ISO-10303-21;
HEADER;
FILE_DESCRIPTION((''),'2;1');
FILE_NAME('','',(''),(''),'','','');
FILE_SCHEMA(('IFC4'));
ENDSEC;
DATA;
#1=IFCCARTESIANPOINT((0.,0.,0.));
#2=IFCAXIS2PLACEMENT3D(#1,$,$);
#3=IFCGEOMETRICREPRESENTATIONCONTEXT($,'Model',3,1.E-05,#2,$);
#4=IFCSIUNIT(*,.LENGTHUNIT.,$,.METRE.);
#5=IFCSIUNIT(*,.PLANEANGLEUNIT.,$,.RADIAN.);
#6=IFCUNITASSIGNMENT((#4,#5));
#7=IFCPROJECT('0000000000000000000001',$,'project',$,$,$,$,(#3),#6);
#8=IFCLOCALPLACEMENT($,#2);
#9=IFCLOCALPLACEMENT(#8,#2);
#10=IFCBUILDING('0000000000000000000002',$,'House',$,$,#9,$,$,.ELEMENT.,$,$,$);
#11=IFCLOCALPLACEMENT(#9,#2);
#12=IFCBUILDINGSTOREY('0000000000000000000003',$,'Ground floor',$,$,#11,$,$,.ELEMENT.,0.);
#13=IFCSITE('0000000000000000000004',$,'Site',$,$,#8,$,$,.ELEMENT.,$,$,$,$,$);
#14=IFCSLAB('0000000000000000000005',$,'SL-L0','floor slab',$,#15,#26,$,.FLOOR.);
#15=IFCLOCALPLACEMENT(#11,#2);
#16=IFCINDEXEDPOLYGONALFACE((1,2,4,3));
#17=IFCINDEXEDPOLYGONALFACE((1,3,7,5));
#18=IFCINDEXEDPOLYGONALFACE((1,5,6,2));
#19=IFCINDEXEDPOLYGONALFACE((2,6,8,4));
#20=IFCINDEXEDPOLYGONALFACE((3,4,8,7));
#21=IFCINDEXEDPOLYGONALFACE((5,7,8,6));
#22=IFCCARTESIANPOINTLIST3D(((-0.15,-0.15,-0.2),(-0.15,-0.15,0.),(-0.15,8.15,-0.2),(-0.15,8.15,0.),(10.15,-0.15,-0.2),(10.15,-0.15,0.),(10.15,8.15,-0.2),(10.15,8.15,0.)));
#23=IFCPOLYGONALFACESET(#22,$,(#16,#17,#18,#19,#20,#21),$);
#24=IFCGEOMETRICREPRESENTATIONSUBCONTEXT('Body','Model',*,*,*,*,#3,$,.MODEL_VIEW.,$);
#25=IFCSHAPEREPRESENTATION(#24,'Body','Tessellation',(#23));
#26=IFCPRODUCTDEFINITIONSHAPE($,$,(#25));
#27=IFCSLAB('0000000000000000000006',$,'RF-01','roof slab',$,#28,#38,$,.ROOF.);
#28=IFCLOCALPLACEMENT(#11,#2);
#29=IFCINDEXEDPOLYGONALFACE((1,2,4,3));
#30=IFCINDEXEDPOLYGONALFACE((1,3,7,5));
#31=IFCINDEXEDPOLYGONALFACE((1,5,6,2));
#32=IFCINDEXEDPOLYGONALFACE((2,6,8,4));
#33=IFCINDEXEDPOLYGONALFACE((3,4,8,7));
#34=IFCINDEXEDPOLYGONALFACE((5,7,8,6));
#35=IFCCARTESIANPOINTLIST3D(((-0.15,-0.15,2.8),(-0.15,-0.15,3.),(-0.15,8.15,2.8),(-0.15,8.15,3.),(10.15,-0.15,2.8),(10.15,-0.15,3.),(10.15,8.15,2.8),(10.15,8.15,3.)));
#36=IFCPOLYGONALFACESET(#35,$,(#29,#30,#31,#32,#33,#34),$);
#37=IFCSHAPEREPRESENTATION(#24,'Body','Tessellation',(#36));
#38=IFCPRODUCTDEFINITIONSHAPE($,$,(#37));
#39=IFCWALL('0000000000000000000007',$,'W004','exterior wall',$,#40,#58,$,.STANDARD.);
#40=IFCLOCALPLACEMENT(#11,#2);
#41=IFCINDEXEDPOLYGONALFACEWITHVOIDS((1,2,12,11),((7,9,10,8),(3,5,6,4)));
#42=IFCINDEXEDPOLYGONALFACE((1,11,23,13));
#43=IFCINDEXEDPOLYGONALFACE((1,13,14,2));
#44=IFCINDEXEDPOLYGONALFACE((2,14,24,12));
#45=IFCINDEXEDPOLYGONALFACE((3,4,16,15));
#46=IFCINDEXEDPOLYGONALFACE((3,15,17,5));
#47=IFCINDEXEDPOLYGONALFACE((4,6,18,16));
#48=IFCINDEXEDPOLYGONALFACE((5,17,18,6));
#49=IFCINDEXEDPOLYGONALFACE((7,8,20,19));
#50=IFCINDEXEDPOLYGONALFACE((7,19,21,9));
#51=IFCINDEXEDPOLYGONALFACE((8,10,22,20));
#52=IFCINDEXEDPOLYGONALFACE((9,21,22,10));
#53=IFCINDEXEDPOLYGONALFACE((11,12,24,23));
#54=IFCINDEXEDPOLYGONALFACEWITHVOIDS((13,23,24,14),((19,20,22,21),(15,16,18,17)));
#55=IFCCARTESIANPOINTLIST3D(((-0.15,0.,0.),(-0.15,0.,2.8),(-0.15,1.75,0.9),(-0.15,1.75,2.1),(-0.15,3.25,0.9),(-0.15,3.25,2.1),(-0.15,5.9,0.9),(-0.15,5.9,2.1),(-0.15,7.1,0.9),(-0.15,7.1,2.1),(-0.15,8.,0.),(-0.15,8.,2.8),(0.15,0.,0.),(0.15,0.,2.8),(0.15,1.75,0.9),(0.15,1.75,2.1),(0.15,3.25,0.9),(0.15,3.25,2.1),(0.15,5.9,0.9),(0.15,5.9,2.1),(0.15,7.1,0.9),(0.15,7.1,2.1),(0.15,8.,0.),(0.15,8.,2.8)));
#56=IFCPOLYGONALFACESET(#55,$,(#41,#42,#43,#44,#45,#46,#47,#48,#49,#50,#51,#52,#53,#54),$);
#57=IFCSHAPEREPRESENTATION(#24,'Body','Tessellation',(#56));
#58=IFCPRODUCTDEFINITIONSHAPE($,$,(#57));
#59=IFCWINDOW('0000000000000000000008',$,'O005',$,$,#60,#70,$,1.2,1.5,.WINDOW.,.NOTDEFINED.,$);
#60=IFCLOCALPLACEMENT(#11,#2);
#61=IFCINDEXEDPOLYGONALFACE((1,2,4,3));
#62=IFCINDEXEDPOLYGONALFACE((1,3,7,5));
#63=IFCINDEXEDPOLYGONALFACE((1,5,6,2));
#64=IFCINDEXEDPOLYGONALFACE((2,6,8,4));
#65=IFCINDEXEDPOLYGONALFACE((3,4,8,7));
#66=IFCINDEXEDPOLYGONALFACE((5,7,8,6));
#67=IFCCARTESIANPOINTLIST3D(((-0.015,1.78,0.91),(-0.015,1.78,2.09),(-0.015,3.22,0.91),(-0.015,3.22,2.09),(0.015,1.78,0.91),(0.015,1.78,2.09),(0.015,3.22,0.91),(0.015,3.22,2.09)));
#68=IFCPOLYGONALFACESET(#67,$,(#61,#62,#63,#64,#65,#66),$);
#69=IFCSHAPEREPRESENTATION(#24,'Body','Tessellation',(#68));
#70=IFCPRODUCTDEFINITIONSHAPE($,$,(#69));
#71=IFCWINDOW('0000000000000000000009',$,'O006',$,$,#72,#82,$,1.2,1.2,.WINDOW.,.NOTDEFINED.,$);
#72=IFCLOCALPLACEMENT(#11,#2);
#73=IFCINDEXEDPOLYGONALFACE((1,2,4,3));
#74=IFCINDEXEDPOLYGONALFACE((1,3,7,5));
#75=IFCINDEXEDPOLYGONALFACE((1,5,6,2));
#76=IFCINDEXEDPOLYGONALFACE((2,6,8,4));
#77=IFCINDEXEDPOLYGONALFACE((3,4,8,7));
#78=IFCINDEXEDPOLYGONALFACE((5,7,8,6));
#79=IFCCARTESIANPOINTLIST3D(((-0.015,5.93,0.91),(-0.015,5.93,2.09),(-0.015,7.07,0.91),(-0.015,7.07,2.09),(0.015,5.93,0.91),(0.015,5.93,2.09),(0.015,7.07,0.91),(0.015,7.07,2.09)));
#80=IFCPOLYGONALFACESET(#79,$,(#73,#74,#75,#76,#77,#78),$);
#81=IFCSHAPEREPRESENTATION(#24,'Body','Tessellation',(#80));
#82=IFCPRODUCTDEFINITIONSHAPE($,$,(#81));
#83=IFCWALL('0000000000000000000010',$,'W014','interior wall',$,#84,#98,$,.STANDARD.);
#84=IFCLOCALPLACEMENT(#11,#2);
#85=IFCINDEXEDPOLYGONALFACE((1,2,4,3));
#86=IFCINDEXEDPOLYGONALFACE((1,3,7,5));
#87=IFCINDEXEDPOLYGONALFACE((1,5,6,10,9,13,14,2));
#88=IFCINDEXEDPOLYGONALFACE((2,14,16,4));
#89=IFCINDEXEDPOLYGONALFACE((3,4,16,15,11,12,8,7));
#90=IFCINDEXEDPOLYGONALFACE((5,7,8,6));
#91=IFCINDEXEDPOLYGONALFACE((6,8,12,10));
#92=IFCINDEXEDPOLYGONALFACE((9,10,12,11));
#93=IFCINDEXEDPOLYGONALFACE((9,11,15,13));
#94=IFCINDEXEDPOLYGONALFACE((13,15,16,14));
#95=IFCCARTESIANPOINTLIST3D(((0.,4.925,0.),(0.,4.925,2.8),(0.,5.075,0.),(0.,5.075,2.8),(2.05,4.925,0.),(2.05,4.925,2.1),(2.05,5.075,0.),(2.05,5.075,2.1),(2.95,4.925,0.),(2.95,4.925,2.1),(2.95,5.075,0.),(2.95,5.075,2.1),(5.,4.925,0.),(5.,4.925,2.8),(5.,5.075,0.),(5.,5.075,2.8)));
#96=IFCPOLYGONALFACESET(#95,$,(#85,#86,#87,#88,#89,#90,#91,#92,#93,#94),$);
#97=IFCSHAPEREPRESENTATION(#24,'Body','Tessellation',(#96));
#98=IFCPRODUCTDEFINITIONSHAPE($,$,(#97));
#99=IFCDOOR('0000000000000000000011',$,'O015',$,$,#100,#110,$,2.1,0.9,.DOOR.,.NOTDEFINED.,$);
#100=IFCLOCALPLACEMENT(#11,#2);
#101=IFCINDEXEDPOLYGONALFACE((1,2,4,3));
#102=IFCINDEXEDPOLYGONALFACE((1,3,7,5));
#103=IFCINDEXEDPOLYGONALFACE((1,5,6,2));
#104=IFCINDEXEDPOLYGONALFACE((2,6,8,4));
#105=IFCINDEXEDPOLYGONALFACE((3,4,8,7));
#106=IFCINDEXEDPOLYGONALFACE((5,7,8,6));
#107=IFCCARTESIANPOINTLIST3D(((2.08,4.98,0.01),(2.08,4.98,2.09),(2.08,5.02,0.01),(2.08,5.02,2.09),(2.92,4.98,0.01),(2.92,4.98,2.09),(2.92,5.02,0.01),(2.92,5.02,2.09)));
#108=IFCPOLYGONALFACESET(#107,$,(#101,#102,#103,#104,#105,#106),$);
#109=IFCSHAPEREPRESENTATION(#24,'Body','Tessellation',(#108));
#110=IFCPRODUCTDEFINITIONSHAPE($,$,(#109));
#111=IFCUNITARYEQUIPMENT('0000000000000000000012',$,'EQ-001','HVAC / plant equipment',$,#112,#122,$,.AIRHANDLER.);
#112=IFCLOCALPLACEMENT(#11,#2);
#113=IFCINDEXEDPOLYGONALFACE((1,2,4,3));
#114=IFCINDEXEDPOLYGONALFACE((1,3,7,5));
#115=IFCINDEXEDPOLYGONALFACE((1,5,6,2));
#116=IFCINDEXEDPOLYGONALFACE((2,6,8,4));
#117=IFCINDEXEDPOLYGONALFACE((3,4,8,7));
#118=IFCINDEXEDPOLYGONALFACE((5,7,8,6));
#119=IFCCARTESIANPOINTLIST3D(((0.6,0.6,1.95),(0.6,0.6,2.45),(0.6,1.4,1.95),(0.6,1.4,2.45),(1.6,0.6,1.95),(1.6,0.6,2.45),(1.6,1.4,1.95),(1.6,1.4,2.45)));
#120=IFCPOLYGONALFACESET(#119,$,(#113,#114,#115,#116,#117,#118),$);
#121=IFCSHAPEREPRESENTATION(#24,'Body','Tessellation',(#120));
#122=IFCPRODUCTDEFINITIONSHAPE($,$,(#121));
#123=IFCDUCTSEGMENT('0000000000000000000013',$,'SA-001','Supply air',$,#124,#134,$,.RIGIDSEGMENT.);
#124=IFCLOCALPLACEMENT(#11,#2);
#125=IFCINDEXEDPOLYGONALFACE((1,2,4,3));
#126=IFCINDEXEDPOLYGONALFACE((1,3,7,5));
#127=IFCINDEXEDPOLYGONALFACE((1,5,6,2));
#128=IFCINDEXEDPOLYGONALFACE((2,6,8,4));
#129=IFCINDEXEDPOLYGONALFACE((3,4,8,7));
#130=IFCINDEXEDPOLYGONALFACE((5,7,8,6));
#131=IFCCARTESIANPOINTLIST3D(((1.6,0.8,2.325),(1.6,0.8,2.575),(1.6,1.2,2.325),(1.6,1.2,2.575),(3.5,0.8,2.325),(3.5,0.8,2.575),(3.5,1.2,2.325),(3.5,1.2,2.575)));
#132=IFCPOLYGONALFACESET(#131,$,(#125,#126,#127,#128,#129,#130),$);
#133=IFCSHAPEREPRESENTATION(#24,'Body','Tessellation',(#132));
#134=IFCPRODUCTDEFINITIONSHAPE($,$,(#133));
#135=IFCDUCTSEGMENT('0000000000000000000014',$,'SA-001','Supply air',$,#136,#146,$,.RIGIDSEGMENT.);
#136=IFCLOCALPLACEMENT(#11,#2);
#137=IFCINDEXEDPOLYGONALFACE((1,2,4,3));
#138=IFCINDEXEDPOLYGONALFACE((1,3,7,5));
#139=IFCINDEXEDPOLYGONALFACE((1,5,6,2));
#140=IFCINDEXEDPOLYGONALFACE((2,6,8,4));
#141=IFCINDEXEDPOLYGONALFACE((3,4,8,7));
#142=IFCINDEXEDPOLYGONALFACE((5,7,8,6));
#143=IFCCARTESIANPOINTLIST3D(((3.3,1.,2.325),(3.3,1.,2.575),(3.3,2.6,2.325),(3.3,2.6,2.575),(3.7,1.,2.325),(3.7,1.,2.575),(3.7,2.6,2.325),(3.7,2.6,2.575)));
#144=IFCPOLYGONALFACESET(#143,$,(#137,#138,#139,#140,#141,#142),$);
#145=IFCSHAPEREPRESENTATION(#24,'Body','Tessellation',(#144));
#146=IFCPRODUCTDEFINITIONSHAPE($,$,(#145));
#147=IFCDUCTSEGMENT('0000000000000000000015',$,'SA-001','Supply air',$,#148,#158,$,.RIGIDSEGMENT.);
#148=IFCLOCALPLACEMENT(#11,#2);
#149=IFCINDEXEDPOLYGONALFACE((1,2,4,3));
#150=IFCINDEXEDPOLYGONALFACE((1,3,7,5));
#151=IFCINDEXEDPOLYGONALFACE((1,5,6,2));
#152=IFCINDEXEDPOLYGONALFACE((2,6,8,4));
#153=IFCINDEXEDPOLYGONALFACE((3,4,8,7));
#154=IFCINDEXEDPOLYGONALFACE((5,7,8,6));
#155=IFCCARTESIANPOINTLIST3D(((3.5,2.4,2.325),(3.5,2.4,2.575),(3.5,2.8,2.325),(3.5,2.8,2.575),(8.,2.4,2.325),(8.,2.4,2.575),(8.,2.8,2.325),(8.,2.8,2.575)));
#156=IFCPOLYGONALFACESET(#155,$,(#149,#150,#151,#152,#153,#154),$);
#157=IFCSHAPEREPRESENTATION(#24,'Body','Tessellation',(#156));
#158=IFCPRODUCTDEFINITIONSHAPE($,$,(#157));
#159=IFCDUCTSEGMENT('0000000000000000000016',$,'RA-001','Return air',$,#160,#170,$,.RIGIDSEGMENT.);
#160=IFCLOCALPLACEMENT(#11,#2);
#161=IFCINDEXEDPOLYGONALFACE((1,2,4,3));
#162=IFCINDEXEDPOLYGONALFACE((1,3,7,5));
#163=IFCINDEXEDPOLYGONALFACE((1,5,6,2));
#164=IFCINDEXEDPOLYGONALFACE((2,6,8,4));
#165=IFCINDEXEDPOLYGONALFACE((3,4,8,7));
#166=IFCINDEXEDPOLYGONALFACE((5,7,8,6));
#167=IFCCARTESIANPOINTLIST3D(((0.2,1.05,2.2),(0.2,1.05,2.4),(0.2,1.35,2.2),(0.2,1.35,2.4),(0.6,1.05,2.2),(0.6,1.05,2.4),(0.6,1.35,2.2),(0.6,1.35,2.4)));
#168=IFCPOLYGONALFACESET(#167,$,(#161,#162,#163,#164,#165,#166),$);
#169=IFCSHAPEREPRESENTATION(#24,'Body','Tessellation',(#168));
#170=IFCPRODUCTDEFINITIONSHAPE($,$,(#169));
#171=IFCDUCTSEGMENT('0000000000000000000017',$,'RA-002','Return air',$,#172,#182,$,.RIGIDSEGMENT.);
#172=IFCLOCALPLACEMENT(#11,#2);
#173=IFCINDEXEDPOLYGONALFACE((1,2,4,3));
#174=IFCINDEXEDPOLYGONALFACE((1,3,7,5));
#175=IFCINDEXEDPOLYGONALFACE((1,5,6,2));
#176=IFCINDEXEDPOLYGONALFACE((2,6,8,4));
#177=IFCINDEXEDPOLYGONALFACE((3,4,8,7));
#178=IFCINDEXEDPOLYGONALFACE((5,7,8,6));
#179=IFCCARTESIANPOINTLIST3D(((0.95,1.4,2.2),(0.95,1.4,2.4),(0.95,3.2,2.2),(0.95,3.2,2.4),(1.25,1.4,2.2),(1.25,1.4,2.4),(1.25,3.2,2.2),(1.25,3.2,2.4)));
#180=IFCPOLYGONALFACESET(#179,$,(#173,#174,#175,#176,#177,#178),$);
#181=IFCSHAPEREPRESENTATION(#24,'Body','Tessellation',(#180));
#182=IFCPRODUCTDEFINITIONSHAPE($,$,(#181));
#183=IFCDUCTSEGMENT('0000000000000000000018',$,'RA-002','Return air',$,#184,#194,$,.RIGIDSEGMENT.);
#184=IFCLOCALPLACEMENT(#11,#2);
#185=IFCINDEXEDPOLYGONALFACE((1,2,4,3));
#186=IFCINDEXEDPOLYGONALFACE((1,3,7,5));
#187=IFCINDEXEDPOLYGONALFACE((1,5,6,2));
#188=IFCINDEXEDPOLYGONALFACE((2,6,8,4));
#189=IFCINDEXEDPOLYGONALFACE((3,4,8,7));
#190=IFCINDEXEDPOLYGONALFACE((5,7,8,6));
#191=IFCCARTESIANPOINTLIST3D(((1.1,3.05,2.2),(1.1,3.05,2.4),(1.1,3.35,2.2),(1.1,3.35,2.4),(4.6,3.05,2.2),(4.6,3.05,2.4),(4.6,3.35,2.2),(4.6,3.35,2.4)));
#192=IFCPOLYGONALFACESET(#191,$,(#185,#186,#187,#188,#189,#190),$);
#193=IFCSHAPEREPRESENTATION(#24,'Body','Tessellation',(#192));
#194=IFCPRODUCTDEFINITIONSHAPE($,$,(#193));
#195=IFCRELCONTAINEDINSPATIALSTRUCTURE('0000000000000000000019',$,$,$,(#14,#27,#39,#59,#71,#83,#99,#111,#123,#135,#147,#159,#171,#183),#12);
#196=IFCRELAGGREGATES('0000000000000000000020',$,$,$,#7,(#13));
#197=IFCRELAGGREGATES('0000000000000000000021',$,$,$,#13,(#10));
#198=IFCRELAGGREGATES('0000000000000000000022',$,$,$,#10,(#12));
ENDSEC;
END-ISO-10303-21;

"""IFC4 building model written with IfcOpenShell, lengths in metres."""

from ifc_helpers import new_model, si_unit, frame, origin, origin_2d, place, context, subcontext, project, spatial, polyline, rectangle, outline, extrude, element, fill, save


model = new_model("IFC4")

# Units and contexts
model_context = context("Model", 3, precision=1e-05, world=origin())
body_context = subcontext(model_context, "Body", "Model", "MODEL_VIEW")
ifc_project = project(units=[si_unit("LENGTHUNIT", "METRE"), si_unit("PLANEANGLEUNIT", "RADIAN")], contexts=[model_context])

# Site, building, storey
site_placement = place(None, origin())
site = spatial("IfcSite", under=ifc_project, at=site_placement, Name="Site", CompositionType="ELEMENT")
building_placement = place(site_placement, origin())
building = spatial("IfcBuilding", under=site, at=building_placement, Name="House", CompositionType="ELEMENT")
storey_placement = place(building_placement, origin())
storey = spatial("IfcBuildingStorey", under=building, at=storey_placement, Name="Ground floor", CompositionType="ELEMENT", Elevation=0.0)

# Slabs
slab_1_placement = place(storey_placement, frame((0.0, 0.0, -0.2)))
element("IfcSlab", 1, at=slab_1_placement, inside=storey, Name="SL-L0", Description="floor slab", PredefinedType="FLOOR", context=body_context, shape_type="SweptSolid", body=[
    extrude(outline(polyline([(-0.15, 8.15), (10.15, 8.15), (10.15, -0.15), (-0.15, -0.15), (-0.15, 8.15)])), origin(), (0.0, 0.0, 1.0), 0.2),
])
slab_2_placement = place(storey_placement, frame((0.0, 0.0, 2.8)))
element("IfcSlab", 2, at=slab_2_placement, inside=storey, Name="RF-01", Description="roof slab", PredefinedType="ROOF", context=body_context, shape_type="SweptSolid", body=[
    extrude(outline(polyline([(-0.15, 8.15), (10.15, 8.15), (10.15, -0.15), (-0.15, -0.15), (-0.15, 8.15)])), origin(), (0.0, 0.0, 1.0), 0.2),
])

# Wall, openings, windows
wall_1_placement = place(storey_placement, frame((0.0, 4.0, 0.0), z_axis=(0.0, 0.0, 1.0), x_axis=(0.0, 1.0, 0.0)))
wall_1 = element("IfcWall", 3, at=wall_1_placement, inside=storey, Name="W004", Description="exterior wall", PredefinedType="STANDARD", context=body_context, shape_type="SweptSolid", body=[
    extrude(rectangle(XDim=8.0, YDim=0.3, at=origin_2d()), origin(), (0.0, 0.0, 1.0), 2.8),
])
opening_1_placement = place(wall_1_placement, frame((-1.5, 0.0, 0.9)))
opening_1 = element("IfcOpeningElement", 4, at=opening_1_placement, cuts=wall_1, PredefinedType="OPENING", context=body_context, shape_type="SweptSolid", body=[
    extrude(rectangle(XDim=1.5, YDim=0.36, at=origin_2d()), origin(), (0.0, 0.0, 1.0), 1.2),
])
opening_2_placement = place(wall_1_placement, frame((2.5, 0.0, 0.9)))
opening_2 = element("IfcOpeningElement", 5, at=opening_2_placement, cuts=wall_1, PredefinedType="OPENING", context=body_context, shape_type="SweptSolid", body=[
    extrude(rectangle(XDim=1.2, YDim=0.36, at=origin_2d()), origin(), (0.0, 0.0, 1.0), 1.2),
])
window_1_placement = place(wall_1_placement, frame((-1.5, 0.0, 0.9)))
window_1 = element("IfcWindow", 6, at=window_1_placement, inside=storey, Name="O005", OverallHeight=1.2, OverallWidth=1.5, PartitioningType="NOTDEFINED", PredefinedType="WINDOW", context=body_context, shape_type="SweptSolid", body=[
    extrude(rectangle(XDim=1.44, YDim=0.03, at=origin_2d()), frame((0.0, 0.0, 0.01)), (0.0, 0.0, 1.0), 1.18),
])
fill(opening_1, window_1)
window_2_placement = place(wall_1_placement, frame((2.5, 0.0, 0.9)))
window_2 = element("IfcWindow", 7, at=window_2_placement, inside=storey, Name="O006", OverallHeight=1.2, OverallWidth=1.2, PartitioningType="NOTDEFINED", PredefinedType="WINDOW", context=body_context, shape_type="SweptSolid", body=[
    extrude(rectangle(XDim=1.14, YDim=0.03, at=origin_2d()), frame((0.0, 0.0, 0.01)), (0.0, 0.0, 1.0), 1.18),
])
fill(opening_2, window_2)

# Wall, opening, door
wall_2_placement = place(storey_placement, frame((2.5, 5.0, 0.0), z_axis=(0.0, 0.0, 1.0), x_axis=(1.0, 0.0, 0.0)))
wall_2 = element("IfcWall", 8, at=wall_2_placement, inside=storey, Name="W014", Description="interior wall", PredefinedType="STANDARD", context=body_context, shape_type="SweptSolid", body=[
    extrude(rectangle(XDim=5.0, YDim=0.15, at=origin_2d()), origin(), (0.0, 0.0, 1.0), 2.8),
])
opening_3_placement = place(wall_2_placement, origin())
opening_3 = element("IfcOpeningElement", 9, at=opening_3_placement, cuts=wall_2, PredefinedType="OPENING", context=body_context, shape_type="SweptSolid", body=[
    extrude(rectangle(XDim=0.9, YDim=0.18, at=origin_2d()), origin(), (0.0, 0.0, 1.0), 2.1),
])
door_placement = place(wall_2_placement, origin())
door = element("IfcDoor", 10, at=door_placement, inside=storey, Name="O015", OperationType="NOTDEFINED", OverallHeight=2.1, OverallWidth=0.9, PredefinedType="DOOR", context=body_context, shape_type="SweptSolid", body=[
    extrude(rectangle(XDim=0.84, YDim=0.04, at=origin_2d()), frame((0.0, 0.0, 0.01)), (0.0, 0.0, 1.0), 2.08),
])
fill(opening_3, door)

# Unitary equipment
unitary_equipment_placement = place(storey_placement, frame((1.1, 1.0, 1.95), z_axis=(0.0, 0.0, 1.0), x_axis=(1.0, 0.0, 0.0)))
element("IfcUnitaryEquipment", 11, at=unitary_equipment_placement, inside=storey, Name="EQ-001", Description="HVAC / plant equipment", PredefinedType="AIRHANDLER", context=body_context, shape_type="SweptSolid", body=[
    extrude(rectangle(XDim=1.0, YDim=0.8, at=origin_2d()), origin(), (0.0, 0.0, 1.0), 0.5),
])

# Duct segments
duct_segment_1_placement = place(storey_placement, frame((1.6, 1.0, 2.45), z_axis=(1.0, 0.0, 0.0), x_axis=(0.0, 1.0, 0.0)))
element("IfcDuctSegment", 12, at=duct_segment_1_placement, inside=storey, Name="SA-001", Description="Supply air", PredefinedType="RIGIDSEGMENT", context=body_context, shape_type="SweptSolid", body=[
    extrude(rectangle(XDim=0.4, YDim=0.25, at=origin_2d()), origin(), (0.0, 0.0, 1.0), 1.9),
])
duct_segment_2_placement = place(storey_placement, frame((3.5, 1.0, 2.45), z_axis=(0.0, 1.0, 0.0), x_axis=(-1.0, 0.0, 0.0)))
element("IfcDuctSegment", 13, at=duct_segment_2_placement, inside=storey, Name="SA-001", Description="Supply air", PredefinedType="RIGIDSEGMENT", context=body_context, shape_type="SweptSolid", body=[
    extrude(rectangle(XDim=0.4, YDim=0.25, at=origin_2d()), origin(), (0.0, 0.0, 1.0), 1.6),
])
duct_segment_3_placement = place(storey_placement, frame((3.5, 2.6, 2.45), z_axis=(1.0, 0.0, 0.0), x_axis=(0.0, 1.0, 0.0)))
element("IfcDuctSegment", 14, at=duct_segment_3_placement, inside=storey, Name="SA-001", Description="Supply air", PredefinedType="RIGIDSEGMENT", context=body_context, shape_type="SweptSolid", body=[
    extrude(rectangle(XDim=0.4, YDim=0.25, at=origin_2d()), origin(), (0.0, 0.0, 1.0), 4.5),
])
duct_segment_4_placement = place(storey_placement, frame((0.6, 1.2, 2.3), z_axis=(-1.0, 0.0, 0.0), x_axis=(0.0, -1.0, 0.0)))
element("IfcDuctSegment", 15, at=duct_segment_4_placement, inside=storey, Name="RA-001", Description="Return air", PredefinedType="RIGIDSEGMENT", context=body_context, shape_type="SweptSolid", body=[
    extrude(rectangle(XDim=0.3, YDim=0.2, at=origin_2d()), origin(), (0.0, 0.0, 1.0), 0.4),
])
duct_segment_5_placement = place(storey_placement, frame((1.1, 1.4, 2.3), z_axis=(0.0, 1.0, 0.0), x_axis=(-1.0, 0.0, 0.0)))
element("IfcDuctSegment", 16, at=duct_segment_5_placement, inside=storey, Name="RA-002", Description="Return air", PredefinedType="RIGIDSEGMENT", context=body_context, shape_type="SweptSolid", body=[
    extrude(rectangle(XDim=0.3, YDim=0.2, at=origin_2d()), origin(), (0.0, 0.0, 1.0), 1.8),
])
duct_segment_6_placement = place(storey_placement, frame((1.1, 3.2, 2.3), z_axis=(1.0, 0.0, 0.0), x_axis=(0.0, 1.0, 0.0)))
element("IfcDuctSegment", 17, at=duct_segment_6_placement, inside=storey, Name="RA-002", Description="Return air", PredefinedType="RIGIDSEGMENT", context=body_context, shape_type="SweptSolid", body=[
    extrude(rectangle(XDim=0.3, YDim=0.2, at=origin_2d()), origin(), (0.0, 0.0, 1.0), 3.5),
])

save(model, "model.ifc")
